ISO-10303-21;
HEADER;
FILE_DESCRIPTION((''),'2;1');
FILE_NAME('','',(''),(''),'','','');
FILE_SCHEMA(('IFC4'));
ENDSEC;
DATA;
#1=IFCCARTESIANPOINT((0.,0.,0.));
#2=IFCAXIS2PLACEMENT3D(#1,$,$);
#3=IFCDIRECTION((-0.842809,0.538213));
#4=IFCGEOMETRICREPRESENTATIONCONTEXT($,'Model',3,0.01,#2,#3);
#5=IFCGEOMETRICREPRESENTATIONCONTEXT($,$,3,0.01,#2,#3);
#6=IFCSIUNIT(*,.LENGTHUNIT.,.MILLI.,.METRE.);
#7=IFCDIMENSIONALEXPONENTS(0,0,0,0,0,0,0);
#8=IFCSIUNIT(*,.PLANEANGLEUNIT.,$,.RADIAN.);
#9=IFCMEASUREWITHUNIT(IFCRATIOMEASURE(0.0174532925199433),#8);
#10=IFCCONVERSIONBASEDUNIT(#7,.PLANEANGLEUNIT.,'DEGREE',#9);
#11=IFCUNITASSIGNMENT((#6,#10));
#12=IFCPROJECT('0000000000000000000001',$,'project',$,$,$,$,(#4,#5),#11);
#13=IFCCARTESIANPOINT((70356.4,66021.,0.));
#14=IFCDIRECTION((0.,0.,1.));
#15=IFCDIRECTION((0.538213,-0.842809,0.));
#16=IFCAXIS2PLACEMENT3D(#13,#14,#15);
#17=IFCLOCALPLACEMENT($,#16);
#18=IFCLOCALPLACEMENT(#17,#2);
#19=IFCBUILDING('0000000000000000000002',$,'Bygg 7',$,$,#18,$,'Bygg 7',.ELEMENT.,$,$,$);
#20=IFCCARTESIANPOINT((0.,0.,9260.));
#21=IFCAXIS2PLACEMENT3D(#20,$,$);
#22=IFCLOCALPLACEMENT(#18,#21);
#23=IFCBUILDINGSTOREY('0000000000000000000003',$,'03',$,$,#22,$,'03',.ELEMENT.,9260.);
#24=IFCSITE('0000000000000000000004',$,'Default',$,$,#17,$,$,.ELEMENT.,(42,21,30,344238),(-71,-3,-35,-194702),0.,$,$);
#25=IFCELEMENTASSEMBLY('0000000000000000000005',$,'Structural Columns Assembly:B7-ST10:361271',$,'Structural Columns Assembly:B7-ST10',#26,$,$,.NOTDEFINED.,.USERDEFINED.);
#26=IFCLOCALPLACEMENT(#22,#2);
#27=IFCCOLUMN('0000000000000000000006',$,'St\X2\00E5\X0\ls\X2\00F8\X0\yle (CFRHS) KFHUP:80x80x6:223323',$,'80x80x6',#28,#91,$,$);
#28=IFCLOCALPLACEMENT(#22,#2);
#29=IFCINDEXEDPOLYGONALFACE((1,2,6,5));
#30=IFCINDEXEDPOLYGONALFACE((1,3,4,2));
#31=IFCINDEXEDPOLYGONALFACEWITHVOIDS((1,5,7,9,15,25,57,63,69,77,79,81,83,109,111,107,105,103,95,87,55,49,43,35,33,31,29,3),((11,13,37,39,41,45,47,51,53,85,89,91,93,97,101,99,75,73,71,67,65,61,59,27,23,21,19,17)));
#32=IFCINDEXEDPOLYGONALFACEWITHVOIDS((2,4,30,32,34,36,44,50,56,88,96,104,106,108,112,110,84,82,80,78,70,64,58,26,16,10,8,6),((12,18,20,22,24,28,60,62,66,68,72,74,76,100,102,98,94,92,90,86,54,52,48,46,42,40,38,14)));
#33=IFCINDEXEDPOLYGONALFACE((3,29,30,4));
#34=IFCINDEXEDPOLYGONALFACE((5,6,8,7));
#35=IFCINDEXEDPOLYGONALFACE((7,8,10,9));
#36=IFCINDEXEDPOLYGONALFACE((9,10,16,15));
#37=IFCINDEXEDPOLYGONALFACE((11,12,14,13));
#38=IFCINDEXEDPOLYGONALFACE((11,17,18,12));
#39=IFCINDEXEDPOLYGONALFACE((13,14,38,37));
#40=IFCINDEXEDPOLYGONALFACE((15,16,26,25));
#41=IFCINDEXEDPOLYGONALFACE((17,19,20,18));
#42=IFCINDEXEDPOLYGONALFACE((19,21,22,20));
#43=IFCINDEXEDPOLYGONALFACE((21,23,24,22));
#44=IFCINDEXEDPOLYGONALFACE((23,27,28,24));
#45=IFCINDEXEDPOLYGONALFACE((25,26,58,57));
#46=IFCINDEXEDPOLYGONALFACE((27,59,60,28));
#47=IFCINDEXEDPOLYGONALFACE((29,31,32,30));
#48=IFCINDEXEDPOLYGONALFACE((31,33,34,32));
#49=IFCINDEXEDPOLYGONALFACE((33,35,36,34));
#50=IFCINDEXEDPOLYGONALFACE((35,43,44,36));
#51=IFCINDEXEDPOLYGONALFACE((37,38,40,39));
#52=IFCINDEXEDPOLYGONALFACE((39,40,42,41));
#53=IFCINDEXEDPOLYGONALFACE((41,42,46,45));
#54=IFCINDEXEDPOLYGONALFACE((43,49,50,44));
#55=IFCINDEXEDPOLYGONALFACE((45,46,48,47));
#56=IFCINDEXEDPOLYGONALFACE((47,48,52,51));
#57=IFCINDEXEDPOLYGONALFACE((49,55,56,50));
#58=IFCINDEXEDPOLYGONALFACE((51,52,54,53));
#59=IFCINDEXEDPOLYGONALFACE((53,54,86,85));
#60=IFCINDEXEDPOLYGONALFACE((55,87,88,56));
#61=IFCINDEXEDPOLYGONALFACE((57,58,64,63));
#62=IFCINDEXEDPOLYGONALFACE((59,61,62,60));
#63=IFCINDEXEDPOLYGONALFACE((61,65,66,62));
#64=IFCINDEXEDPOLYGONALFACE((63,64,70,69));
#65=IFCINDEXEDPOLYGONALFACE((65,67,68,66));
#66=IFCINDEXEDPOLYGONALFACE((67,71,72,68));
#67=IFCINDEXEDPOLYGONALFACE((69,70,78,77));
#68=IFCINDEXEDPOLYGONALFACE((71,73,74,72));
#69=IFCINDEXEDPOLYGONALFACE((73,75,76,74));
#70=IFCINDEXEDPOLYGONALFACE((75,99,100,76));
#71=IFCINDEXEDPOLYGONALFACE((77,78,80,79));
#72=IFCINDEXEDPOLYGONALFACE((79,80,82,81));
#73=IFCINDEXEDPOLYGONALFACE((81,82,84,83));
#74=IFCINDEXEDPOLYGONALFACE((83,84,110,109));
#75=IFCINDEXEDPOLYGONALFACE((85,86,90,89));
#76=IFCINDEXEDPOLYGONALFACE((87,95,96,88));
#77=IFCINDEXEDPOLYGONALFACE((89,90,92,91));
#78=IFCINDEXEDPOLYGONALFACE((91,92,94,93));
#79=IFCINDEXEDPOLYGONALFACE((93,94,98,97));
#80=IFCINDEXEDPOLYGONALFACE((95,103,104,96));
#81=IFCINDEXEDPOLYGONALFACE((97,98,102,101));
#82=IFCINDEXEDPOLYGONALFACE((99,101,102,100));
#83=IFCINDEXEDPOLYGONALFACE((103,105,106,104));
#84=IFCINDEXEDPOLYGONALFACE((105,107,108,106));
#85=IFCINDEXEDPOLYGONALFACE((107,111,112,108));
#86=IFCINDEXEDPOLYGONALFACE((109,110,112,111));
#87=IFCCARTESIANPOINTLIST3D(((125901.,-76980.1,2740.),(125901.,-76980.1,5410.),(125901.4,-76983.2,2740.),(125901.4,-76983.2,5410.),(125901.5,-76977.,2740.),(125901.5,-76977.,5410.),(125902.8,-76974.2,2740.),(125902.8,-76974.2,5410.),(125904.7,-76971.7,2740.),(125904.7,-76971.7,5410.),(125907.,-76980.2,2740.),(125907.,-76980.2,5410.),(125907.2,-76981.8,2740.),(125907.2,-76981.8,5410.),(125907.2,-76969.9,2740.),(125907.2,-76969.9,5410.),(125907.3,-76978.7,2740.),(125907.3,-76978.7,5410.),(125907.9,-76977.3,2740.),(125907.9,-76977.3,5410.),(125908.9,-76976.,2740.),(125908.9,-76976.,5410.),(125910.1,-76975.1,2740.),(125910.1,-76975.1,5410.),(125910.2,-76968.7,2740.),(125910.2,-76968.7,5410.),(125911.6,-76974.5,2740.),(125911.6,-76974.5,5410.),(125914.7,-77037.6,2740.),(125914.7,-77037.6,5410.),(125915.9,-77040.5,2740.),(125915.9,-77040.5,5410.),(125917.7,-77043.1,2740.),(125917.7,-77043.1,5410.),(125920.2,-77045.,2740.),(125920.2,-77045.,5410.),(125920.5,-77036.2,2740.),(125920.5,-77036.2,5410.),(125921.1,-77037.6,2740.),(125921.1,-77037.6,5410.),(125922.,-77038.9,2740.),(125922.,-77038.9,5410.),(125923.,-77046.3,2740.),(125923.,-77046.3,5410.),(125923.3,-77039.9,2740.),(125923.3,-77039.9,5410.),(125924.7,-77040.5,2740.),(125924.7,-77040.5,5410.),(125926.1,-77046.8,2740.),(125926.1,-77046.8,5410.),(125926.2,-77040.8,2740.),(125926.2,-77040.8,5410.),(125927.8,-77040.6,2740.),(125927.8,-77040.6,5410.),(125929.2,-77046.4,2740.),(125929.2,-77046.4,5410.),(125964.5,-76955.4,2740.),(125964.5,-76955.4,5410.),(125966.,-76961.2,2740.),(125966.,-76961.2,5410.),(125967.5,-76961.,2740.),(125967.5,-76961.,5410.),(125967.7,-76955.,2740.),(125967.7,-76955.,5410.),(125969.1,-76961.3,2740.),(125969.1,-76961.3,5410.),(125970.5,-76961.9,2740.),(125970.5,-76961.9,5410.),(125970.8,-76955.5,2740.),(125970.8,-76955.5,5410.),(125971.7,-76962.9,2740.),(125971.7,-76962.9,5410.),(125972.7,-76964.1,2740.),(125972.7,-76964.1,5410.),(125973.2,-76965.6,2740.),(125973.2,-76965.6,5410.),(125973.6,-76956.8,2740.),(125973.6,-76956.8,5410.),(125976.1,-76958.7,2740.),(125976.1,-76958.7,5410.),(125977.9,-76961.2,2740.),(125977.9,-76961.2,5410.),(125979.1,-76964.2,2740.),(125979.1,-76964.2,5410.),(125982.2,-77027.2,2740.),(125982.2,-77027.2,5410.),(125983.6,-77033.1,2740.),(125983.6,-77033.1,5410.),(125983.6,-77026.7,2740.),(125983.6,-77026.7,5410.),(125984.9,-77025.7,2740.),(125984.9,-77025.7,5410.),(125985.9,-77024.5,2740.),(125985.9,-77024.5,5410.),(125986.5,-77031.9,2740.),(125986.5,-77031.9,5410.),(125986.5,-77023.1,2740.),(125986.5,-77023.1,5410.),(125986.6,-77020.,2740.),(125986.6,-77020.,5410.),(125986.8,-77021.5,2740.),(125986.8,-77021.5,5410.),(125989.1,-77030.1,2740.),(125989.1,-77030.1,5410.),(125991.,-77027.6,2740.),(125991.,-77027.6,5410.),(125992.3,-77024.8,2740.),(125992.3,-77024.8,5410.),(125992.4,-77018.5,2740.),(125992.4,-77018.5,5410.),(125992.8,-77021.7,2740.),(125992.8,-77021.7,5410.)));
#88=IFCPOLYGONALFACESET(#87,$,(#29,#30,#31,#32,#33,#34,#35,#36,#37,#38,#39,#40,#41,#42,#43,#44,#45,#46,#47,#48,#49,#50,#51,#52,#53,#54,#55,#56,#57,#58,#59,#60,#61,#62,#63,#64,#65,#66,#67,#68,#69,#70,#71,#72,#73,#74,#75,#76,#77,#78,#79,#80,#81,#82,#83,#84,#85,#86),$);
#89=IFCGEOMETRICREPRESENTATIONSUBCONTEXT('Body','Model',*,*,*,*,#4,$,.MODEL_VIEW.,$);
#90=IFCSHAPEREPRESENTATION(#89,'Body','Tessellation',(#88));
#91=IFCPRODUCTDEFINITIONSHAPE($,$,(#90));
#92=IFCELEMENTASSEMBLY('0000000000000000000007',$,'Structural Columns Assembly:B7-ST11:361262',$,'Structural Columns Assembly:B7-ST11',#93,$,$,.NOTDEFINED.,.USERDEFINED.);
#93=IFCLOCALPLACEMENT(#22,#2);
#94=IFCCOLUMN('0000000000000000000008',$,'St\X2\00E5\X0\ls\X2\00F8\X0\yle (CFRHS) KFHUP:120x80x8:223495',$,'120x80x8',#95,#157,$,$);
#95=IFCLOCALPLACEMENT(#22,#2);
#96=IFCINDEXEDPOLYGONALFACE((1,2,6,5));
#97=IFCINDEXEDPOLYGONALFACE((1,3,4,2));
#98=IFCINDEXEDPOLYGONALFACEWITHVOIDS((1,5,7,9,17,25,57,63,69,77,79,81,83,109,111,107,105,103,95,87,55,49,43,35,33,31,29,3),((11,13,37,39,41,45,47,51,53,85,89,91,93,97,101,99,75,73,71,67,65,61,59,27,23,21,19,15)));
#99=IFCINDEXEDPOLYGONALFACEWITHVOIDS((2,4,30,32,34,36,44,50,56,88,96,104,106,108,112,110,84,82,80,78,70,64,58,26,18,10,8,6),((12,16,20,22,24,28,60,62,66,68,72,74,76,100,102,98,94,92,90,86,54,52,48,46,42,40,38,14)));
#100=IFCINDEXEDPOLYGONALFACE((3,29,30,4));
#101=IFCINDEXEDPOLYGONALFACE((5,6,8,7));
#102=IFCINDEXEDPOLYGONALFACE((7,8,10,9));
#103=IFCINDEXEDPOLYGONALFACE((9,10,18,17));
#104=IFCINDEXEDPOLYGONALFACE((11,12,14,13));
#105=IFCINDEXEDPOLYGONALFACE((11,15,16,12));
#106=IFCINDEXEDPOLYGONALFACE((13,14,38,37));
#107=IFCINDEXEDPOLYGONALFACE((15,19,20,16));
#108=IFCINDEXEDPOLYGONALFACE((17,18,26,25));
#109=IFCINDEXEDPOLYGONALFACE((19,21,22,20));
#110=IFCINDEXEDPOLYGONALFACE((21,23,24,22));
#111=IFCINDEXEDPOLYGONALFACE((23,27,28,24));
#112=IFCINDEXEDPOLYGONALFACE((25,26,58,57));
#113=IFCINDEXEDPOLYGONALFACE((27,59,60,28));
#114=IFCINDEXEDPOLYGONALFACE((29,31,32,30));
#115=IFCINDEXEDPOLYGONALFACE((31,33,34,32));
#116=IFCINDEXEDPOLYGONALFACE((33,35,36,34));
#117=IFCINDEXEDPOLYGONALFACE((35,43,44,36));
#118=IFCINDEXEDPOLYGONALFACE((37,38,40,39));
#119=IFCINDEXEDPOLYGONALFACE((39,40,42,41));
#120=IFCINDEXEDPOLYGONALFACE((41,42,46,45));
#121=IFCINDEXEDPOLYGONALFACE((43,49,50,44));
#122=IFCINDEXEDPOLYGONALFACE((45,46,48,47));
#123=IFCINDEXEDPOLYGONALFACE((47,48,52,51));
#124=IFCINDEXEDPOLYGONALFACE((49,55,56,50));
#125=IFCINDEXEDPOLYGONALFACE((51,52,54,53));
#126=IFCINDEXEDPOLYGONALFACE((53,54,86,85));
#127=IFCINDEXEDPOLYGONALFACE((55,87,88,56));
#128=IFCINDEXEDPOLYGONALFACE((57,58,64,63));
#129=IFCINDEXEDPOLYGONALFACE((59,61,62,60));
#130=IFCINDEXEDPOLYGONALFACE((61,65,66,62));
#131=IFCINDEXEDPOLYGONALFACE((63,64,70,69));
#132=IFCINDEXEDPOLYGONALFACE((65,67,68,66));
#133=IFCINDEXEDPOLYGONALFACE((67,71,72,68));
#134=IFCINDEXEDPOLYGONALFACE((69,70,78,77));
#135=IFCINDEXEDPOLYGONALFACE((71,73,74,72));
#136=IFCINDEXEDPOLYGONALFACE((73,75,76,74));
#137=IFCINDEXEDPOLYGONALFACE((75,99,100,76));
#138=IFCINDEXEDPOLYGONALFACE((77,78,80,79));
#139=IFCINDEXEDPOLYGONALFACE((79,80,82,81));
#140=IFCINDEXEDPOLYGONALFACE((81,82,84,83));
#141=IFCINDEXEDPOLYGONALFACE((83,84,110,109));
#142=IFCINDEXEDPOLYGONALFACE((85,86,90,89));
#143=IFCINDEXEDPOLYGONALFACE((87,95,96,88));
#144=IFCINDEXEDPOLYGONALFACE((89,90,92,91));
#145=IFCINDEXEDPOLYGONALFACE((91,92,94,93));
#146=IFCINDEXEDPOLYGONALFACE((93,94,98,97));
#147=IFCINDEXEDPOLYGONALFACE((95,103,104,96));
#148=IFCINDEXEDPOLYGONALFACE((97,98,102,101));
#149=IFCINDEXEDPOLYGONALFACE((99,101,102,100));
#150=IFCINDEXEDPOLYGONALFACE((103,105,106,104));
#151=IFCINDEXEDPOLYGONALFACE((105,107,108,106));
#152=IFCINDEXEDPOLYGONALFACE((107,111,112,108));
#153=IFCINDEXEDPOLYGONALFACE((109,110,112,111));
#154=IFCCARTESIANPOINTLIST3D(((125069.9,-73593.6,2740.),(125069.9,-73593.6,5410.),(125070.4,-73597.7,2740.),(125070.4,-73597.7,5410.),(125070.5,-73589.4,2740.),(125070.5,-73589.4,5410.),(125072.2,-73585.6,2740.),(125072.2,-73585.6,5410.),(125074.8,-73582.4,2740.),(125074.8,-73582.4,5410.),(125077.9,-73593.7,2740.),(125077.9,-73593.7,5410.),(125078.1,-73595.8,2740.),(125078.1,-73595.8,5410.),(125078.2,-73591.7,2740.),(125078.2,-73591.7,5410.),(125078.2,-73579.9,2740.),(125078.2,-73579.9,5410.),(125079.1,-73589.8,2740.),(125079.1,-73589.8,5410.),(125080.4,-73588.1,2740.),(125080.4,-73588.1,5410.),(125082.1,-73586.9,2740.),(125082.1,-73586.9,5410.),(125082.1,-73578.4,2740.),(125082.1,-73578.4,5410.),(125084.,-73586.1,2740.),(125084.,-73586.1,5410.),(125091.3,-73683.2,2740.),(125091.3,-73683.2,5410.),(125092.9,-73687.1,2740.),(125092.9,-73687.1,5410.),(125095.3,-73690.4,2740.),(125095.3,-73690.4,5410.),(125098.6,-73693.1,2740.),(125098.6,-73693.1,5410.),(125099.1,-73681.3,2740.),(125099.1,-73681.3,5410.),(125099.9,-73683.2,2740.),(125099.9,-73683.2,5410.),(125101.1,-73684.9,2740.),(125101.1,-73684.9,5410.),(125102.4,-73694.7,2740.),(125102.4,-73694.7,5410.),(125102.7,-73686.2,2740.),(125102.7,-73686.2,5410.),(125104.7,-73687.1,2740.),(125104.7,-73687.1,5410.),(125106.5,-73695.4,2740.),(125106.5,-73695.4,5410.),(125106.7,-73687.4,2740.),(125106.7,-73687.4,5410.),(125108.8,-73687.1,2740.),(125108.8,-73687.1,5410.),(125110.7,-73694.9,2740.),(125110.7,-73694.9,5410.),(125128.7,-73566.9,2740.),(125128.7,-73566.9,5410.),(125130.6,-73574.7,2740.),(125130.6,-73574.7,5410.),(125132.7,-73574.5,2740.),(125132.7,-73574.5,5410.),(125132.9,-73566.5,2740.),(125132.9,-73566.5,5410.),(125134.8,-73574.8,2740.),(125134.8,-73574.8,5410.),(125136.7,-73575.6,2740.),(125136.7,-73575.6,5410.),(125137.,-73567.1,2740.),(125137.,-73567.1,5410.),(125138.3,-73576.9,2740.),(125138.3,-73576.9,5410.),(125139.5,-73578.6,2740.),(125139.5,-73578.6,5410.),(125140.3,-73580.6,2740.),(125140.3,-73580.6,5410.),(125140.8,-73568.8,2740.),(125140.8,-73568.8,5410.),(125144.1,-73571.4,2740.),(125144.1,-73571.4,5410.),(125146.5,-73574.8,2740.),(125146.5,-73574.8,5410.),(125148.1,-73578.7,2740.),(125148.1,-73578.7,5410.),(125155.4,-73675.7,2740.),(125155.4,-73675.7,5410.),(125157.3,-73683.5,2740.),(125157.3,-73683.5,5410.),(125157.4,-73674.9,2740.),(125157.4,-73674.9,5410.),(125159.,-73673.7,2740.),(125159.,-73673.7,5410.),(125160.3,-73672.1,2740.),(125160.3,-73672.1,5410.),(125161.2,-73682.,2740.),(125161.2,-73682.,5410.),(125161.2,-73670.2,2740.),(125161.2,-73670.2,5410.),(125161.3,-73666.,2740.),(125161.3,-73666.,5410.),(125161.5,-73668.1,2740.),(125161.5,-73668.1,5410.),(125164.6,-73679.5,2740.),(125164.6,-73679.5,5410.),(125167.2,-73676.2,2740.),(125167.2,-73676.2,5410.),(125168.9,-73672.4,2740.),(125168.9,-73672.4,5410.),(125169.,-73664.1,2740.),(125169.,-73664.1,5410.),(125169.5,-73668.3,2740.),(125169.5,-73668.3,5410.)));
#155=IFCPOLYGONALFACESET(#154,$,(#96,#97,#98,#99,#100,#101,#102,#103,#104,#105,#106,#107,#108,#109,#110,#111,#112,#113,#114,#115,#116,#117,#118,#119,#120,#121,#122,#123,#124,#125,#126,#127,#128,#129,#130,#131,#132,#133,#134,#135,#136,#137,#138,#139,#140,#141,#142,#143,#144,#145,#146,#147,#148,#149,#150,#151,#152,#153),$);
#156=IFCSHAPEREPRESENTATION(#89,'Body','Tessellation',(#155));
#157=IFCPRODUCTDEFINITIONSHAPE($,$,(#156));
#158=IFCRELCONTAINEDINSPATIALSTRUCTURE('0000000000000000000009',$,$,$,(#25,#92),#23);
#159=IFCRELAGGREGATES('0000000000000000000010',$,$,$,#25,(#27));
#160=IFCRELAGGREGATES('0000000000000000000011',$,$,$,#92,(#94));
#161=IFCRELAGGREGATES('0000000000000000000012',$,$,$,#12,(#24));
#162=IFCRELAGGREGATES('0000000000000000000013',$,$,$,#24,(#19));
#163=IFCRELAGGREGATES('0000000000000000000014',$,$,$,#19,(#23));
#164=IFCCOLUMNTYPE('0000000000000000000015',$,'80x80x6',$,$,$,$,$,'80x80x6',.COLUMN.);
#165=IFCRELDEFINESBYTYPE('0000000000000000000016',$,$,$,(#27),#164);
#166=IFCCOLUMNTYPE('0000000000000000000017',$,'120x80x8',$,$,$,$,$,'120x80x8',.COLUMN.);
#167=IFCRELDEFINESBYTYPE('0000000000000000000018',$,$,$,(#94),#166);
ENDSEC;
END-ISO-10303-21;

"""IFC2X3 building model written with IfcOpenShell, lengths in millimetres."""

from ifc_helpers import new_model, entity, si_unit, converted_unit, direction, frame, frame_2d, origin, place, context, subcontext, project, spatial, polyline, circle_curve, parameter, trimmed, segment, composite_curve, outline, extrude, source, transform, mapped, type_object, type_shapes, element, aggregate, save


model = new_model("IFC2X3")

# Units and contexts
model_context = context("Model", 3, precision=0.01, world=origin(), true_north=direction((-0.842809, 0.538213)))
context_of_model = context(None, 3, precision=0.01, world=origin(), true_north=direction((-0.842809, 0.538213)))
body_context = subcontext(model_context, "Body", "Model", "MODEL_VIEW")
ifc_project = project(units=[si_unit("LENGTHUNIT", "METRE", prefix="MILLI"), converted_unit("PLANEANGLEUNIT", "DEGREE", entity("IfcRatioMeasure", 0.0174532925199433), si_unit("PLANEANGLEUNIT", "RADIAN"), dimensions=[0, 0, 0, 0, 0, 0, 0])], contexts=[model_context, context_of_model])

# Site, building, storey
site_placement = place(None, frame((70356.4, 66021.0, 0.0), z_axis=(0.0, 0.0, 1.0), x_axis=(0.538213, -0.842809, 0.0)))
site = spatial("IfcSite", under=ifc_project, at=site_placement, Name="Default", CompositionType="ELEMENT", RefLatitude=(42, 21, 30, 344238), RefLongitude=(-71, -3, -35, -194702), RefElevation=0.0)
building_placement = place(site_placement, origin())
building = spatial("IfcBuilding", under=site, at=building_placement, Name="Bygg 7", LongName="Bygg 7", CompositionType="ELEMENT")
storey_placement = place(building_placement, frame((0.0, 0.0, 9260.0)))
storey = spatial("IfcBuildingStorey", under=building, at=storey_placement, Name="03", LongName="03", CompositionType="ELEMENT", Elevation=9260.0)

# Element assemblies, columns
assembly_1_placement = place(storey_placement, origin())
assembly_1 = element("IfcElementAssembly", 1, at=assembly_1_placement, inside=storey, Name="Structural Columns Assembly:B7-ST10:361271", ObjectType="Structural Columns Assembly:B7-ST10", AssemblyPlace="NOTDEFINED", PredefinedType="USERDEFINED")
column_type_1 = type_object("IfcColumnType", Name="80x80x6", ElementType="80x80x6", PredefinedType="COLUMN")
shared_shape_1 = source(origin(), body_context, "Body", "SweptSolid", [
    extrude(outline(composite_curve([segment(trimmed(circle_curve(frame_2d((-28.0, 28.0), x_axis=(1.0, 0.0)), 12.0), [parameter(90.0)], [parameter(180.0)], True, "PARAMETER"), True, "CONTINUOUS"), segment(polyline([(-40.0, 28.0), (-40.0, -28.0)]), True, "CONTINUOUS"), segment(trimmed(circle_curve(frame_2d((-28.0, -28.0), x_axis=(1.0, 0.0)), 12.0), [parameter(180.0)], [parameter(270.0)], True, "PARAMETER"), True, "CONTINUOUS"), segment(polyline([(-28.0, -40.0), (28.0, -40.0)]), True, "CONTINUOUS"), segment(trimmed(circle_curve(frame_2d((28.0, -28.0), x_axis=(1.0, 0.0)), 12.0), [parameter(270.0)], [parameter(0.0)], True, "PARAMETER"), True, "CONTINUOUS"), segment(polyline([(40.0, -28.0), (40.0, 28.0)]), True, "CONTINUOUS"), segment(trimmed(circle_curve(frame_2d((28.0, 28.0), x_axis=(1.0, 0.0)), 12.0), [parameter(0.0)], [parameter(90.0)], True, "PARAMETER"), True, "CONTINUOUS"), segment(polyline([(28.0, 40.0), (-28.0, 40.0)]), True, "CONTINUOUS")], self_intersect=False), holes=[composite_curve([segment(polyline([(-28.0, 34.0), (28.0, 34.0)]), True, "CONTINUOUS"), segment(trimmed(circle_curve(frame_2d((28.0, 28.0), x_axis=(1.0, 0.0)), 6.0), [parameter(360.0)], [parameter(90.0)], True, "PARAMETER"), False, "CONTINUOUS"), segment(polyline([(34.0, 28.0), (34.0, -28.0)]), True, "CONTINUOUS"), segment(trimmed(circle_curve(frame_2d((28.0, -28.0), x_axis=(1.0, 0.0)), 6.0), [parameter(270.0)], [parameter(360.0)], True, "PARAMETER"), False, "CONTINUOUS"), segment(polyline([(28.0, -34.0), (-28.0, -34.0)]), True, "CONTINUOUS"), segment(trimmed(circle_curve(frame_2d((-28.0, -28.0), x_axis=(1.0, 0.0)), 6.0), [parameter(180.0)], [parameter(270.0)], True, "PARAMETER"), False, "CONTINUOUS"), segment(polyline([(-34.0, -28.0), (-34.0, 28.0)]), True, "CONTINUOUS"), segment(trimmed(circle_curve(frame_2d((-28.0, 28.0), x_axis=(1.0, 0.0)), 6.0), [parameter(90.0)], [parameter(180.0)], True, "PARAMETER"), False, "CONTINUOUS")], self_intersect=False)]), frame((47.5, 47.5, 0.0), z_axis=(0.0, 0.0, 1.0), x_axis=(-0.971172, -0.238381, 0.0)), (0.0, 0.0, 1.0), 2670.0),
])
type_shapes(column_type_1, [shared_shape_1])
column_1_placement = place(assembly_1_placement, frame((125899.4, -77048.3, 2740.0)))
column_1 = element("IfcColumn", 2, at=column_1_placement, type_object=column_type_1, Name="Stålsøyle (CFRHS) KFHUP:80x80x6:223323", ObjectType="80x80x6", context=body_context, shape_type="MappedRepresentation", body=[
    mapped(shared_shape_1, transform((0.0, 0.0, 0.0), scale=1.0)),
])
aggregate(assembly_1, [column_1])
assembly_2_placement = place(storey_placement, origin())
assembly_2 = element("IfcElementAssembly", 3, at=assembly_2_placement, inside=storey, Name="Structural Columns Assembly:B7-ST11:361262", ObjectType="Structural Columns Assembly:B7-ST11", AssemblyPlace="NOTDEFINED", PredefinedType="USERDEFINED")
column_type_2 = type_object("IfcColumnType", Name="120x80x8", ElementType="120x80x8", PredefinedType="COLUMN")
shared_shape_2 = source(origin(), body_context, "Body", "SweptSolid", [
    extrude(outline(composite_curve([segment(trimmed(circle_curve(frame_2d((-24.0, 44.0), x_axis=(1.0, 0.0)), 16.0), [parameter(90.0)], [parameter(180.0)], True, "PARAMETER"), True, "CONTINUOUS"), segment(polyline([(-40.0, 44.0), (-40.0, -44.0)]), True, "CONTINUOUS"), segment(trimmed(circle_curve(frame_2d((-24.0, -44.0), x_axis=(1.0, 0.0)), 16.0), [parameter(180.0)], [parameter(270.0)], True, "PARAMETER"), True, "CONTINUOUS"), segment(polyline([(-24.0, -60.0), (24.0, -60.0)]), True, "CONTINUOUS"), segment(trimmed(circle_curve(frame_2d((24.0, -44.0), x_axis=(1.0, 0.0)), 16.0), [parameter(270.0)], [parameter(0.0)], True, "PARAMETER"), True, "CONTINUOUS"), segment(polyline([(40.0, -44.0), (40.0, 44.0)]), True, "CONTINUOUS"), segment(trimmed(circle_curve(frame_2d((24.0, 44.0), x_axis=(1.0, 0.0)), 16.0), [parameter(0.0)], [parameter(90.0)], True, "PARAMETER"), True, "CONTINUOUS"), segment(polyline([(24.0, 60.0), (-24.0, 60.0)]), True, "CONTINUOUS")], self_intersect=False), holes=[composite_curve([segment(polyline([(-24.0, 52.0), (24.0, 52.0)]), True, "CONTINUOUS"), segment(trimmed(circle_curve(frame_2d((24.0, 44.0), x_axis=(1.0, 0.0)), 8.0), [parameter(360.0)], [parameter(90.0)], True, "PARAMETER"), False, "CONTINUOUS"), segment(polyline([(32.0, 44.0), (32.0, -44.0)]), True, "CONTINUOUS"), segment(trimmed(circle_curve(frame_2d((24.0, -44.0), x_axis=(1.0, 0.0)), 8.0), [parameter(270.0)], [parameter(360.0)], True, "PARAMETER"), False, "CONTINUOUS"), segment(polyline([(24.0, -52.0), (-24.0, -52.0)]), True, "CONTINUOUS"), segment(trimmed(circle_curve(frame_2d((-24.0, -44.0), x_axis=(1.0, 0.0)), 8.0), [parameter(180.0)], [parameter(270.0)], True, "PARAMETER"), False, "CONTINUOUS"), segment(polyline([(-32.0, -44.0), (-32.0, 44.0)]), True, "CONTINUOUS"), segment(trimmed(circle_curve(frame_2d((-24.0, 44.0), x_axis=(1.0, 0.0)), 8.0), [parameter(90.0)], [parameter(180.0)], True, "PARAMETER"), False, "CONTINUOUS")], self_intersect=False)]), frame((51.4, 66.0, 0.0), z_axis=(0.0, 0.0, 1.0), x_axis=(-0.971172, -0.238381, 0.0)), (0.0, 0.0, 1.0), 2670.0),
])
type_shapes(column_type_2, [shared_shape_2])
column_2_placement = place(assembly_2_placement, frame((125068.3, -73697.0, 2740.0)))
column_2 = element("IfcColumn", 4, at=column_2_placement, type_object=column_type_2, Name="Stålsøyle (CFRHS) KFHUP:120x80x8:223495", ObjectType="120x80x8", context=body_context, shape_type="MappedRepresentation", body=[
    mapped(shared_shape_2, transform((0.0, 0.0, 0.0), scale=1.0)),
])
aggregate(assembly_2, [column_2])

save(model, "model.ifc")
